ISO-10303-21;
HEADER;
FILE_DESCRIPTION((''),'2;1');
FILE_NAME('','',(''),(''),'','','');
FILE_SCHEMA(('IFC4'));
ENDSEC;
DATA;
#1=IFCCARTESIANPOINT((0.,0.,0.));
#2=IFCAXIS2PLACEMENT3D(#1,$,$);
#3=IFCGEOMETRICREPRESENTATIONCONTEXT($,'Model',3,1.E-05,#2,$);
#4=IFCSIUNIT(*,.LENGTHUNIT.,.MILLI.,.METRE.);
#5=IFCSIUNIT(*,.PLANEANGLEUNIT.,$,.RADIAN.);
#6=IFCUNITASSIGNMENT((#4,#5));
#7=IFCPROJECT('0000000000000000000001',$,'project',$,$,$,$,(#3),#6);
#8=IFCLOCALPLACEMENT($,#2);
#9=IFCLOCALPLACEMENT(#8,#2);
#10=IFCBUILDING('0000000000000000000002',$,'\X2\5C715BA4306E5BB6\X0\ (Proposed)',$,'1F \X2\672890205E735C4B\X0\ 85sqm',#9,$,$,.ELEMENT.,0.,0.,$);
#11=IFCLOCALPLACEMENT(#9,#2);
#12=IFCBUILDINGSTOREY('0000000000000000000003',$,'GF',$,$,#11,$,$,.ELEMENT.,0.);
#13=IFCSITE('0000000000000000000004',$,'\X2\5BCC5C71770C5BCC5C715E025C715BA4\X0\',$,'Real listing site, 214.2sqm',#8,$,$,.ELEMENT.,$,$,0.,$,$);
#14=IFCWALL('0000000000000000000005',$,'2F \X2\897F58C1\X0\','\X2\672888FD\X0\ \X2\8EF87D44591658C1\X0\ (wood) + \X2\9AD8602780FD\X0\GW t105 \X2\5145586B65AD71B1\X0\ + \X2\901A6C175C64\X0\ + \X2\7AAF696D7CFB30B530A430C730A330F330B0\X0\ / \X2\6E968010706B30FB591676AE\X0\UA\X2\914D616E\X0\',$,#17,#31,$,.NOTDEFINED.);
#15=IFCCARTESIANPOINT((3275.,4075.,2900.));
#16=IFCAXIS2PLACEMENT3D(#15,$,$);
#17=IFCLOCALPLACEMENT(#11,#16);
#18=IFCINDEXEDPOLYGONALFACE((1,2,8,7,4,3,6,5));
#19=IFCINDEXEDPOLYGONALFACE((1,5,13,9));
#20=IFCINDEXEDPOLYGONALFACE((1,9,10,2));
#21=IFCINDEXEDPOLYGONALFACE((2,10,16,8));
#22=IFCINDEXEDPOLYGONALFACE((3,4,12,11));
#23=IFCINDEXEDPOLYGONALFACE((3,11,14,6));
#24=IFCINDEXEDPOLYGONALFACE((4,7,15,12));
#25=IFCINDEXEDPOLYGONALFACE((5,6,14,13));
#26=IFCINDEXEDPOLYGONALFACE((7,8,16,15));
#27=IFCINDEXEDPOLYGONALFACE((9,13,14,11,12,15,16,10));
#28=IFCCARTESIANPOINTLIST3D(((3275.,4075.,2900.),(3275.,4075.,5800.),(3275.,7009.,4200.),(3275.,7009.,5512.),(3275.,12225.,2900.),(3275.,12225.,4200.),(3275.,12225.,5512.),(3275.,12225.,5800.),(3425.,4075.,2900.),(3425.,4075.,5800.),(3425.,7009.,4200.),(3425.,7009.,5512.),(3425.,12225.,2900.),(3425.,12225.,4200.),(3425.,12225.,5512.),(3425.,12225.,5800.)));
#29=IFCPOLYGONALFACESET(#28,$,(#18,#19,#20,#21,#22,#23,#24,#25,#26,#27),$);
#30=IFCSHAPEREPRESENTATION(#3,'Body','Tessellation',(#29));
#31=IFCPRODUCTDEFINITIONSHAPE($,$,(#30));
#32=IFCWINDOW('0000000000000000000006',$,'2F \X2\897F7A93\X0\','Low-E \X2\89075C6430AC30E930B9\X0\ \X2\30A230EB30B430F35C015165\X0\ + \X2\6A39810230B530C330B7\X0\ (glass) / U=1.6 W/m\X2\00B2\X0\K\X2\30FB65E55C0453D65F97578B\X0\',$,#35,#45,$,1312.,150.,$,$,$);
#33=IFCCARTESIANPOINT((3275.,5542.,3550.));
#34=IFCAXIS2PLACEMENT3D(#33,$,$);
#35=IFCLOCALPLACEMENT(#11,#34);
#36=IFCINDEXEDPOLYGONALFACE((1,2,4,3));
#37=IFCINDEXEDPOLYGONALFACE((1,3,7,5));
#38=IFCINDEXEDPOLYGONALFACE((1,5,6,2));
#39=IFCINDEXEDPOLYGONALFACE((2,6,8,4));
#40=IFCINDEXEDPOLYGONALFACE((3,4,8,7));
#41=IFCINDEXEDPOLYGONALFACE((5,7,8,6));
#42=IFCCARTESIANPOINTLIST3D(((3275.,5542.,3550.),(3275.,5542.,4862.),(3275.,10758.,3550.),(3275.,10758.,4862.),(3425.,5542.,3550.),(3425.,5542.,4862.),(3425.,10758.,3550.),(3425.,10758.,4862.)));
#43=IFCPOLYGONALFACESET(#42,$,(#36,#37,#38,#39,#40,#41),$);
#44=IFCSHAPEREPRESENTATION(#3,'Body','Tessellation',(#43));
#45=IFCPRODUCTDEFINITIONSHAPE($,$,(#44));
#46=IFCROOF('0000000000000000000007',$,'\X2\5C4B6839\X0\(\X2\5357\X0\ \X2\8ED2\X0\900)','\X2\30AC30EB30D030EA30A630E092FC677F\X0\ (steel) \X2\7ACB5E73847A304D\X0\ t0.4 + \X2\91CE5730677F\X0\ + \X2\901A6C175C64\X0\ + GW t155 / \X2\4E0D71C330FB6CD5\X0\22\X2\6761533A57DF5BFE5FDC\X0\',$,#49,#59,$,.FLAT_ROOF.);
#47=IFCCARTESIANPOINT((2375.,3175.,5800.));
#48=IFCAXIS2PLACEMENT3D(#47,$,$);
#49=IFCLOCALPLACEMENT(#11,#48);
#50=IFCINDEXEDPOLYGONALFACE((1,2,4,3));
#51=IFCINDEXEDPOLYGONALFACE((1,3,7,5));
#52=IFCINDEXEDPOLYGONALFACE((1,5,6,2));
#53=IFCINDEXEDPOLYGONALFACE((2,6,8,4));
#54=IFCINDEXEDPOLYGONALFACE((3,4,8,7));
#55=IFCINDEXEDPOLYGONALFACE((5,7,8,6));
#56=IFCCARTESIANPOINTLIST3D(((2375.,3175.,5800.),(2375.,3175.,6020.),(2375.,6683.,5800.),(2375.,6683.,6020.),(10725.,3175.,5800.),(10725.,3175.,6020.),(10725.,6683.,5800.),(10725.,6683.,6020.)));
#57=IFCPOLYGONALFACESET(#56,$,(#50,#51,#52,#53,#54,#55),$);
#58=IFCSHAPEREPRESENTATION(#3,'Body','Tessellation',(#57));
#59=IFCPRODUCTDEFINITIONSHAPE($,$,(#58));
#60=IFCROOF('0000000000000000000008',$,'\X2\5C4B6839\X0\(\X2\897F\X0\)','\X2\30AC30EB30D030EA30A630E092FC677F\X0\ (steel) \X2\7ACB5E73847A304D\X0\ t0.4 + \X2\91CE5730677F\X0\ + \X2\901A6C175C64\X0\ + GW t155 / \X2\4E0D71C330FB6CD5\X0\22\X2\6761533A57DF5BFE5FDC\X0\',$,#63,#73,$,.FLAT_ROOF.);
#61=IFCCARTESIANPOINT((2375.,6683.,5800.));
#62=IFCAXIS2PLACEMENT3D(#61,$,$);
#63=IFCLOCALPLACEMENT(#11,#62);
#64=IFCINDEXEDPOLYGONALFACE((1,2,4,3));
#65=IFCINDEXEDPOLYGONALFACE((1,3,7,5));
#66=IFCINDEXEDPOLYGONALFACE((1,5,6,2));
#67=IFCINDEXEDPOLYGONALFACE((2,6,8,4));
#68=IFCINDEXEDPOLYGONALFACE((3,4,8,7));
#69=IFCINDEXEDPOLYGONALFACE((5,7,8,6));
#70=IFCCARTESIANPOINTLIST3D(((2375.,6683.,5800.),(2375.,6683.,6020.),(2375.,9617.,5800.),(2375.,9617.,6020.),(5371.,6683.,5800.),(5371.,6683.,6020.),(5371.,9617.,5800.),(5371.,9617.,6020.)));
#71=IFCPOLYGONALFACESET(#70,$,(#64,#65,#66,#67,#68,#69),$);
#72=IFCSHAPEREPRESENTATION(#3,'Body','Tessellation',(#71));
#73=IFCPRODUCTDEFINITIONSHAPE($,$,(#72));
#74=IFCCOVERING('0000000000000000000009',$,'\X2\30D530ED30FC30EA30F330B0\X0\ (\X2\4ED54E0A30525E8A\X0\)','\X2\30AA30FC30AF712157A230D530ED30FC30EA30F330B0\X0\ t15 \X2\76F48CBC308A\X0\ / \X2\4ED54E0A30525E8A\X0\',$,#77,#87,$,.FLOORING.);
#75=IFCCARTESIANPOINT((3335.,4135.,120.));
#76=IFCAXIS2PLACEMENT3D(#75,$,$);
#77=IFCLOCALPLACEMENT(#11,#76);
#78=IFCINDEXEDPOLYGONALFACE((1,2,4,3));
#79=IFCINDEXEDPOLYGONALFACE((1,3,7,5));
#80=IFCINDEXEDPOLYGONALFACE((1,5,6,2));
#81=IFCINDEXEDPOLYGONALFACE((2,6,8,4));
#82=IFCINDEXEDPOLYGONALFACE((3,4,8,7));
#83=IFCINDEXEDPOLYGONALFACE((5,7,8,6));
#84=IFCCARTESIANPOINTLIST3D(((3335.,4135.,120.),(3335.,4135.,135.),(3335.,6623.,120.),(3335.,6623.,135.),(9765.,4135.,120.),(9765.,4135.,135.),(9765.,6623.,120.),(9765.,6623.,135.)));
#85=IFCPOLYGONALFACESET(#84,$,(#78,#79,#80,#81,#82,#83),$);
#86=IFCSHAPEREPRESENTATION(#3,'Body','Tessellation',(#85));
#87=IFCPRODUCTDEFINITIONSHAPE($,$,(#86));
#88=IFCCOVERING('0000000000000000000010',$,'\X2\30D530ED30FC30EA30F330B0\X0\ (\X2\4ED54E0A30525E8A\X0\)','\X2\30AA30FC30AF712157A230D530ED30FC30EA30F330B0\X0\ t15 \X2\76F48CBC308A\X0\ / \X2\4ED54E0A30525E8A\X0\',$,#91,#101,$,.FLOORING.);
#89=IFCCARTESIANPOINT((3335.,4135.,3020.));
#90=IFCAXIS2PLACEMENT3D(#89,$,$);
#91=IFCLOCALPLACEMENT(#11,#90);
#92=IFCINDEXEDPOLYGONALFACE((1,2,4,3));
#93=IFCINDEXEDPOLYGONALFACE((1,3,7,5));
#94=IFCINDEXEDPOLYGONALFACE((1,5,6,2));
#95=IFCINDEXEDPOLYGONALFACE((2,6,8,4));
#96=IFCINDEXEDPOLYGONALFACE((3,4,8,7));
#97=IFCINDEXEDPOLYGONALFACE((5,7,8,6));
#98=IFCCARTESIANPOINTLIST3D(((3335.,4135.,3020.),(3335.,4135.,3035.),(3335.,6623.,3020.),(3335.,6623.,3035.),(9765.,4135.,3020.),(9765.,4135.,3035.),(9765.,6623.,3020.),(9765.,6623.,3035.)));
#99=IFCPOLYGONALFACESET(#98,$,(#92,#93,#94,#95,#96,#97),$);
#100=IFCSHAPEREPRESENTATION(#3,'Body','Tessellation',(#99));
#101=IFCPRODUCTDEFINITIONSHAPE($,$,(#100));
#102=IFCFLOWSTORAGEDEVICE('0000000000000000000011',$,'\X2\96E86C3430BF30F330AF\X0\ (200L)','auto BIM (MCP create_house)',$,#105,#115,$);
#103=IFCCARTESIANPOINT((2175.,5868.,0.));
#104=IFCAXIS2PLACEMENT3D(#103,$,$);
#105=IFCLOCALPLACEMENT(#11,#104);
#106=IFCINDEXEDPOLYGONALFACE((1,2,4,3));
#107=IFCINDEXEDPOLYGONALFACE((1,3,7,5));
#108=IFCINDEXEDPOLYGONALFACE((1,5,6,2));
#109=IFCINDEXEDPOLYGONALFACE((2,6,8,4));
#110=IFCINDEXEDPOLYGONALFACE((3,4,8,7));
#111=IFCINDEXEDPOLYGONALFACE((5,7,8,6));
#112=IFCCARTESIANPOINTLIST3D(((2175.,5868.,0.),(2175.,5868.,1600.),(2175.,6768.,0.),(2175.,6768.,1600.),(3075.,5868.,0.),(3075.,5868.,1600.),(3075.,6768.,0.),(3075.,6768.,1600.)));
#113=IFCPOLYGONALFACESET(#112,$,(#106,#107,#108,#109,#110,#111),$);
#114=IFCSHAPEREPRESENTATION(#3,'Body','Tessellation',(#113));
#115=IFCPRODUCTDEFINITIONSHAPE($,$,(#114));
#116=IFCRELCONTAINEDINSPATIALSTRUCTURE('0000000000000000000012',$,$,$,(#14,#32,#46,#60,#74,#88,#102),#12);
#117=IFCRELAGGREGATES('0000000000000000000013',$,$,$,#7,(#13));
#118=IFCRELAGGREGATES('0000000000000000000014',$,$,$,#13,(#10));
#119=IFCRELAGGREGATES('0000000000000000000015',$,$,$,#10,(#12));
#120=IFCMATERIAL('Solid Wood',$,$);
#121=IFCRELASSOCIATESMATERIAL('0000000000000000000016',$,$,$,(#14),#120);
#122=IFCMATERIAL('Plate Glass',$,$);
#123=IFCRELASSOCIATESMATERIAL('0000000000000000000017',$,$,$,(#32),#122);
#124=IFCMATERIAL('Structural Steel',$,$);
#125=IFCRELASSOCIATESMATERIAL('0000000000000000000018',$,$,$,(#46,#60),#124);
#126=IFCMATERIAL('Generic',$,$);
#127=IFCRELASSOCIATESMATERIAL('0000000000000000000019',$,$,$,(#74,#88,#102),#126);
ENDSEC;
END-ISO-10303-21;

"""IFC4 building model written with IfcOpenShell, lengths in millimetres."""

from ifc_helpers import new_model, si_unit, frame, frame_2d, origin, place, context, project, spatial, rectangle, extrude, material, element, fill, save


model = new_model("IFC4")

# Units and contexts
model_context = context("Model", 3, precision=1e-05, world=origin())
ifc_project = project(units=[si_unit("LENGTHUNIT", "METRE", prefix="MILLI"), si_unit("PLANEANGLEUNIT", "RADIAN")], contexts=[model_context])

# Site, building, storey
site_placement = place(None, origin())
site = spatial("IfcSite", under=ifc_project, at=site_placement, Name="富山県富山市山室", ObjectType="Real listing site, 214.2sqm", CompositionType="ELEMENT", RefElevation=0.0)
building_placement = place(site_placement, origin())
building = spatial("IfcBuilding", under=site, at=building_placement, Name="山室の家 (Proposed)", ObjectType="1F 木造平屋 85sqm", CompositionType="ELEMENT", ElevationOfRefHeight=0.0, ElevationOfTerrain=0.0)
storey_placement = place(building_placement, origin())
storey = spatial("IfcBuildingStorey", under=building, at=storey_placement, Name="GF", CompositionType="ELEMENT", Elevation=0.0)

# Shared definitions
ifc_material_1 = material(Name="Solid Wood")
ifc_material_2 = material(Name="Generic")

# Shared definitions
ifc_material_3 = material(Name="Plate Glass")

# Wall, opening, window
wall_1_placement = place(storey_placement, frame((3275.0, 4075.0, 2900.0)))
wall_1 = element("IfcWall", 1, at=wall_1_placement, inside=storey, material=ifc_material_1, Name="2F 西壁", Description="木製 軸組外壁 (wood) + 高性能GW t105 充填断熱 + 通気層 + 窯業系サイディング / 準耐火・外皮UA配慮", PredefinedType="NOTDEFINED", context=model_context, shape_type="SweptSolid", body=[
    extrude(rectangle(XDim=150.0, YDim=8150.0, at=frame_2d((75.0, 4075.0))), frame((3275.0, 4075.0, 2900.0)), (0.0, 0.0, 1.0), 2900.0),
])
opening_1_placement = place(storey_placement, frame((3275.0, 5542.0, 3550.0)))
opening_1 = element("IfcOpeningElement", 2, at=opening_1_placement, cuts=wall_1, PredefinedType="NOTDEFINED", context=model_context, shape_type="SweptSolid", body=[
    extrude(rectangle(XDim=150.0, YDim=5216.0, at=frame_2d((75.0, 2608.0))), frame((3275.0, 5542.0, 3550.0)), (0.0, 0.0, 1.0), 1312.0),
])
window_1_placement = place(storey_placement, frame((3275.0, 5542.0, 3550.0)))
window_1 = element("IfcWindow", 3, at=window_1_placement, inside=storey, material=ifc_material_3, Name="2F 西窓", Description="Low-E 複層ガラス アルゴン封入 + 樹脂サッシ (glass) / U=1.6 W/m²K・日射取得型", OverallHeight=1312.0, OverallWidth=150.0, context=model_context, shape_type="SweptSolid", body=[
    extrude(rectangle(XDim=150.0, YDim=5216.0, at=frame_2d((75.0, 2608.0))), frame((3275.0, 5542.0, 3550.0)), (0.0, 0.0, 1.0), 1312.0),
])
fill(opening_1, window_1)

# Roofs
ifc_material_4 = material(Name="Structural Steel")
roof_1_placement = place(storey_placement, frame((2375.0, 3175.0, 5800.0)))
element("IfcRoof", 4, at=roof_1_placement, inside=storey, material=ifc_material_4, Name="屋根(南 軒900)", Description="ガルバリウム鋼板 (steel) 立平葺き t0.4 + 野地板 + 通気層 + GW t155 / 不燃・法22条区域対応", PredefinedType="FLAT_ROOF", context=model_context, shape_type="SweptSolid", body=[
    extrude(rectangle(XDim=8350.0, YDim=3508.0, at=frame_2d((4175.0, 1754.0))), frame((2375.0, 3175.0, 5800.0)), (0.0, 0.0, 1.0), 220.0),
])
roof_2_placement = place(storey_placement, frame((2375.0, 6683.0, 5800.0)))
element("IfcRoof", 5, at=roof_2_placement, inside=storey, material=ifc_material_4, Name="屋根(西)", Description="ガルバリウム鋼板 (steel) 立平葺き t0.4 + 野地板 + 通気層 + GW t155 / 不燃・法22条区域対応", PredefinedType="FLAT_ROOF", context=model_context, shape_type="SweptSolid", body=[
    extrude(rectangle(XDim=2996.0, YDim=2934.0, at=frame_2d((1498.0, 1467.0))), frame((2375.0, 6683.0, 5800.0)), (0.0, 0.0, 1.0), 220.0),
])

# Coverings
covering_1_placement = place(storey_placement, frame((3335.0, 4135.0, 120.0)))
element("IfcCovering", 6, at=covering_1_placement, inside=storey, material=ifc_material_2, Name="フローリング (仕上げ床)", Description="オーク無垢フローリング t15 直貼り / 仕上げ床", PredefinedType="FLOORING", context=model_context, shape_type="SweptSolid", body=[
    extrude(rectangle(XDim=6430.0, YDim=2488.0, at=frame_2d((3215.0, 1244.0))), frame((3335.0, 4135.0, 120.0)), (0.0, 0.0, 1.0), 15.0),
])
covering_2_placement = place(storey_placement, frame((3335.0, 4135.0, 3020.0)))
element("IfcCovering", 7, at=covering_2_placement, inside=storey, material=ifc_material_2, Name="フローリング (仕上げ床)", Description="オーク無垢フローリング t15 直貼り / 仕上げ床", PredefinedType="FLOORING", context=model_context, shape_type="SweptSolid", body=[
    extrude(rectangle(XDim=6430.0, YDim=2488.0, at=frame_2d((3215.0, 1244.0))), frame((3335.0, 4135.0, 3020.0)), (0.0, 0.0, 1.0), 15.0),
])

# Flow storage device
flow_storage_device_placement = place(storey_placement, frame((2175.0, 5868.0, 0.0)))
element("IfcFlowStorageDevice", 8, at=flow_storage_device_placement, inside=storey, material=ifc_material_2, Name="雨水タンク (200L)", Description="auto BIM (MCP create_house)", context=model_context, shape_type="SweptSolid", body=[
    extrude(rectangle(XDim=900.0, YDim=900.0, at=frame_2d((450.0, 450.0))), frame((2175.0, 5868.0, 0.0)), (0.0, 0.0, 1.0), 1600.0),
])

save(model, "model.ifc")
